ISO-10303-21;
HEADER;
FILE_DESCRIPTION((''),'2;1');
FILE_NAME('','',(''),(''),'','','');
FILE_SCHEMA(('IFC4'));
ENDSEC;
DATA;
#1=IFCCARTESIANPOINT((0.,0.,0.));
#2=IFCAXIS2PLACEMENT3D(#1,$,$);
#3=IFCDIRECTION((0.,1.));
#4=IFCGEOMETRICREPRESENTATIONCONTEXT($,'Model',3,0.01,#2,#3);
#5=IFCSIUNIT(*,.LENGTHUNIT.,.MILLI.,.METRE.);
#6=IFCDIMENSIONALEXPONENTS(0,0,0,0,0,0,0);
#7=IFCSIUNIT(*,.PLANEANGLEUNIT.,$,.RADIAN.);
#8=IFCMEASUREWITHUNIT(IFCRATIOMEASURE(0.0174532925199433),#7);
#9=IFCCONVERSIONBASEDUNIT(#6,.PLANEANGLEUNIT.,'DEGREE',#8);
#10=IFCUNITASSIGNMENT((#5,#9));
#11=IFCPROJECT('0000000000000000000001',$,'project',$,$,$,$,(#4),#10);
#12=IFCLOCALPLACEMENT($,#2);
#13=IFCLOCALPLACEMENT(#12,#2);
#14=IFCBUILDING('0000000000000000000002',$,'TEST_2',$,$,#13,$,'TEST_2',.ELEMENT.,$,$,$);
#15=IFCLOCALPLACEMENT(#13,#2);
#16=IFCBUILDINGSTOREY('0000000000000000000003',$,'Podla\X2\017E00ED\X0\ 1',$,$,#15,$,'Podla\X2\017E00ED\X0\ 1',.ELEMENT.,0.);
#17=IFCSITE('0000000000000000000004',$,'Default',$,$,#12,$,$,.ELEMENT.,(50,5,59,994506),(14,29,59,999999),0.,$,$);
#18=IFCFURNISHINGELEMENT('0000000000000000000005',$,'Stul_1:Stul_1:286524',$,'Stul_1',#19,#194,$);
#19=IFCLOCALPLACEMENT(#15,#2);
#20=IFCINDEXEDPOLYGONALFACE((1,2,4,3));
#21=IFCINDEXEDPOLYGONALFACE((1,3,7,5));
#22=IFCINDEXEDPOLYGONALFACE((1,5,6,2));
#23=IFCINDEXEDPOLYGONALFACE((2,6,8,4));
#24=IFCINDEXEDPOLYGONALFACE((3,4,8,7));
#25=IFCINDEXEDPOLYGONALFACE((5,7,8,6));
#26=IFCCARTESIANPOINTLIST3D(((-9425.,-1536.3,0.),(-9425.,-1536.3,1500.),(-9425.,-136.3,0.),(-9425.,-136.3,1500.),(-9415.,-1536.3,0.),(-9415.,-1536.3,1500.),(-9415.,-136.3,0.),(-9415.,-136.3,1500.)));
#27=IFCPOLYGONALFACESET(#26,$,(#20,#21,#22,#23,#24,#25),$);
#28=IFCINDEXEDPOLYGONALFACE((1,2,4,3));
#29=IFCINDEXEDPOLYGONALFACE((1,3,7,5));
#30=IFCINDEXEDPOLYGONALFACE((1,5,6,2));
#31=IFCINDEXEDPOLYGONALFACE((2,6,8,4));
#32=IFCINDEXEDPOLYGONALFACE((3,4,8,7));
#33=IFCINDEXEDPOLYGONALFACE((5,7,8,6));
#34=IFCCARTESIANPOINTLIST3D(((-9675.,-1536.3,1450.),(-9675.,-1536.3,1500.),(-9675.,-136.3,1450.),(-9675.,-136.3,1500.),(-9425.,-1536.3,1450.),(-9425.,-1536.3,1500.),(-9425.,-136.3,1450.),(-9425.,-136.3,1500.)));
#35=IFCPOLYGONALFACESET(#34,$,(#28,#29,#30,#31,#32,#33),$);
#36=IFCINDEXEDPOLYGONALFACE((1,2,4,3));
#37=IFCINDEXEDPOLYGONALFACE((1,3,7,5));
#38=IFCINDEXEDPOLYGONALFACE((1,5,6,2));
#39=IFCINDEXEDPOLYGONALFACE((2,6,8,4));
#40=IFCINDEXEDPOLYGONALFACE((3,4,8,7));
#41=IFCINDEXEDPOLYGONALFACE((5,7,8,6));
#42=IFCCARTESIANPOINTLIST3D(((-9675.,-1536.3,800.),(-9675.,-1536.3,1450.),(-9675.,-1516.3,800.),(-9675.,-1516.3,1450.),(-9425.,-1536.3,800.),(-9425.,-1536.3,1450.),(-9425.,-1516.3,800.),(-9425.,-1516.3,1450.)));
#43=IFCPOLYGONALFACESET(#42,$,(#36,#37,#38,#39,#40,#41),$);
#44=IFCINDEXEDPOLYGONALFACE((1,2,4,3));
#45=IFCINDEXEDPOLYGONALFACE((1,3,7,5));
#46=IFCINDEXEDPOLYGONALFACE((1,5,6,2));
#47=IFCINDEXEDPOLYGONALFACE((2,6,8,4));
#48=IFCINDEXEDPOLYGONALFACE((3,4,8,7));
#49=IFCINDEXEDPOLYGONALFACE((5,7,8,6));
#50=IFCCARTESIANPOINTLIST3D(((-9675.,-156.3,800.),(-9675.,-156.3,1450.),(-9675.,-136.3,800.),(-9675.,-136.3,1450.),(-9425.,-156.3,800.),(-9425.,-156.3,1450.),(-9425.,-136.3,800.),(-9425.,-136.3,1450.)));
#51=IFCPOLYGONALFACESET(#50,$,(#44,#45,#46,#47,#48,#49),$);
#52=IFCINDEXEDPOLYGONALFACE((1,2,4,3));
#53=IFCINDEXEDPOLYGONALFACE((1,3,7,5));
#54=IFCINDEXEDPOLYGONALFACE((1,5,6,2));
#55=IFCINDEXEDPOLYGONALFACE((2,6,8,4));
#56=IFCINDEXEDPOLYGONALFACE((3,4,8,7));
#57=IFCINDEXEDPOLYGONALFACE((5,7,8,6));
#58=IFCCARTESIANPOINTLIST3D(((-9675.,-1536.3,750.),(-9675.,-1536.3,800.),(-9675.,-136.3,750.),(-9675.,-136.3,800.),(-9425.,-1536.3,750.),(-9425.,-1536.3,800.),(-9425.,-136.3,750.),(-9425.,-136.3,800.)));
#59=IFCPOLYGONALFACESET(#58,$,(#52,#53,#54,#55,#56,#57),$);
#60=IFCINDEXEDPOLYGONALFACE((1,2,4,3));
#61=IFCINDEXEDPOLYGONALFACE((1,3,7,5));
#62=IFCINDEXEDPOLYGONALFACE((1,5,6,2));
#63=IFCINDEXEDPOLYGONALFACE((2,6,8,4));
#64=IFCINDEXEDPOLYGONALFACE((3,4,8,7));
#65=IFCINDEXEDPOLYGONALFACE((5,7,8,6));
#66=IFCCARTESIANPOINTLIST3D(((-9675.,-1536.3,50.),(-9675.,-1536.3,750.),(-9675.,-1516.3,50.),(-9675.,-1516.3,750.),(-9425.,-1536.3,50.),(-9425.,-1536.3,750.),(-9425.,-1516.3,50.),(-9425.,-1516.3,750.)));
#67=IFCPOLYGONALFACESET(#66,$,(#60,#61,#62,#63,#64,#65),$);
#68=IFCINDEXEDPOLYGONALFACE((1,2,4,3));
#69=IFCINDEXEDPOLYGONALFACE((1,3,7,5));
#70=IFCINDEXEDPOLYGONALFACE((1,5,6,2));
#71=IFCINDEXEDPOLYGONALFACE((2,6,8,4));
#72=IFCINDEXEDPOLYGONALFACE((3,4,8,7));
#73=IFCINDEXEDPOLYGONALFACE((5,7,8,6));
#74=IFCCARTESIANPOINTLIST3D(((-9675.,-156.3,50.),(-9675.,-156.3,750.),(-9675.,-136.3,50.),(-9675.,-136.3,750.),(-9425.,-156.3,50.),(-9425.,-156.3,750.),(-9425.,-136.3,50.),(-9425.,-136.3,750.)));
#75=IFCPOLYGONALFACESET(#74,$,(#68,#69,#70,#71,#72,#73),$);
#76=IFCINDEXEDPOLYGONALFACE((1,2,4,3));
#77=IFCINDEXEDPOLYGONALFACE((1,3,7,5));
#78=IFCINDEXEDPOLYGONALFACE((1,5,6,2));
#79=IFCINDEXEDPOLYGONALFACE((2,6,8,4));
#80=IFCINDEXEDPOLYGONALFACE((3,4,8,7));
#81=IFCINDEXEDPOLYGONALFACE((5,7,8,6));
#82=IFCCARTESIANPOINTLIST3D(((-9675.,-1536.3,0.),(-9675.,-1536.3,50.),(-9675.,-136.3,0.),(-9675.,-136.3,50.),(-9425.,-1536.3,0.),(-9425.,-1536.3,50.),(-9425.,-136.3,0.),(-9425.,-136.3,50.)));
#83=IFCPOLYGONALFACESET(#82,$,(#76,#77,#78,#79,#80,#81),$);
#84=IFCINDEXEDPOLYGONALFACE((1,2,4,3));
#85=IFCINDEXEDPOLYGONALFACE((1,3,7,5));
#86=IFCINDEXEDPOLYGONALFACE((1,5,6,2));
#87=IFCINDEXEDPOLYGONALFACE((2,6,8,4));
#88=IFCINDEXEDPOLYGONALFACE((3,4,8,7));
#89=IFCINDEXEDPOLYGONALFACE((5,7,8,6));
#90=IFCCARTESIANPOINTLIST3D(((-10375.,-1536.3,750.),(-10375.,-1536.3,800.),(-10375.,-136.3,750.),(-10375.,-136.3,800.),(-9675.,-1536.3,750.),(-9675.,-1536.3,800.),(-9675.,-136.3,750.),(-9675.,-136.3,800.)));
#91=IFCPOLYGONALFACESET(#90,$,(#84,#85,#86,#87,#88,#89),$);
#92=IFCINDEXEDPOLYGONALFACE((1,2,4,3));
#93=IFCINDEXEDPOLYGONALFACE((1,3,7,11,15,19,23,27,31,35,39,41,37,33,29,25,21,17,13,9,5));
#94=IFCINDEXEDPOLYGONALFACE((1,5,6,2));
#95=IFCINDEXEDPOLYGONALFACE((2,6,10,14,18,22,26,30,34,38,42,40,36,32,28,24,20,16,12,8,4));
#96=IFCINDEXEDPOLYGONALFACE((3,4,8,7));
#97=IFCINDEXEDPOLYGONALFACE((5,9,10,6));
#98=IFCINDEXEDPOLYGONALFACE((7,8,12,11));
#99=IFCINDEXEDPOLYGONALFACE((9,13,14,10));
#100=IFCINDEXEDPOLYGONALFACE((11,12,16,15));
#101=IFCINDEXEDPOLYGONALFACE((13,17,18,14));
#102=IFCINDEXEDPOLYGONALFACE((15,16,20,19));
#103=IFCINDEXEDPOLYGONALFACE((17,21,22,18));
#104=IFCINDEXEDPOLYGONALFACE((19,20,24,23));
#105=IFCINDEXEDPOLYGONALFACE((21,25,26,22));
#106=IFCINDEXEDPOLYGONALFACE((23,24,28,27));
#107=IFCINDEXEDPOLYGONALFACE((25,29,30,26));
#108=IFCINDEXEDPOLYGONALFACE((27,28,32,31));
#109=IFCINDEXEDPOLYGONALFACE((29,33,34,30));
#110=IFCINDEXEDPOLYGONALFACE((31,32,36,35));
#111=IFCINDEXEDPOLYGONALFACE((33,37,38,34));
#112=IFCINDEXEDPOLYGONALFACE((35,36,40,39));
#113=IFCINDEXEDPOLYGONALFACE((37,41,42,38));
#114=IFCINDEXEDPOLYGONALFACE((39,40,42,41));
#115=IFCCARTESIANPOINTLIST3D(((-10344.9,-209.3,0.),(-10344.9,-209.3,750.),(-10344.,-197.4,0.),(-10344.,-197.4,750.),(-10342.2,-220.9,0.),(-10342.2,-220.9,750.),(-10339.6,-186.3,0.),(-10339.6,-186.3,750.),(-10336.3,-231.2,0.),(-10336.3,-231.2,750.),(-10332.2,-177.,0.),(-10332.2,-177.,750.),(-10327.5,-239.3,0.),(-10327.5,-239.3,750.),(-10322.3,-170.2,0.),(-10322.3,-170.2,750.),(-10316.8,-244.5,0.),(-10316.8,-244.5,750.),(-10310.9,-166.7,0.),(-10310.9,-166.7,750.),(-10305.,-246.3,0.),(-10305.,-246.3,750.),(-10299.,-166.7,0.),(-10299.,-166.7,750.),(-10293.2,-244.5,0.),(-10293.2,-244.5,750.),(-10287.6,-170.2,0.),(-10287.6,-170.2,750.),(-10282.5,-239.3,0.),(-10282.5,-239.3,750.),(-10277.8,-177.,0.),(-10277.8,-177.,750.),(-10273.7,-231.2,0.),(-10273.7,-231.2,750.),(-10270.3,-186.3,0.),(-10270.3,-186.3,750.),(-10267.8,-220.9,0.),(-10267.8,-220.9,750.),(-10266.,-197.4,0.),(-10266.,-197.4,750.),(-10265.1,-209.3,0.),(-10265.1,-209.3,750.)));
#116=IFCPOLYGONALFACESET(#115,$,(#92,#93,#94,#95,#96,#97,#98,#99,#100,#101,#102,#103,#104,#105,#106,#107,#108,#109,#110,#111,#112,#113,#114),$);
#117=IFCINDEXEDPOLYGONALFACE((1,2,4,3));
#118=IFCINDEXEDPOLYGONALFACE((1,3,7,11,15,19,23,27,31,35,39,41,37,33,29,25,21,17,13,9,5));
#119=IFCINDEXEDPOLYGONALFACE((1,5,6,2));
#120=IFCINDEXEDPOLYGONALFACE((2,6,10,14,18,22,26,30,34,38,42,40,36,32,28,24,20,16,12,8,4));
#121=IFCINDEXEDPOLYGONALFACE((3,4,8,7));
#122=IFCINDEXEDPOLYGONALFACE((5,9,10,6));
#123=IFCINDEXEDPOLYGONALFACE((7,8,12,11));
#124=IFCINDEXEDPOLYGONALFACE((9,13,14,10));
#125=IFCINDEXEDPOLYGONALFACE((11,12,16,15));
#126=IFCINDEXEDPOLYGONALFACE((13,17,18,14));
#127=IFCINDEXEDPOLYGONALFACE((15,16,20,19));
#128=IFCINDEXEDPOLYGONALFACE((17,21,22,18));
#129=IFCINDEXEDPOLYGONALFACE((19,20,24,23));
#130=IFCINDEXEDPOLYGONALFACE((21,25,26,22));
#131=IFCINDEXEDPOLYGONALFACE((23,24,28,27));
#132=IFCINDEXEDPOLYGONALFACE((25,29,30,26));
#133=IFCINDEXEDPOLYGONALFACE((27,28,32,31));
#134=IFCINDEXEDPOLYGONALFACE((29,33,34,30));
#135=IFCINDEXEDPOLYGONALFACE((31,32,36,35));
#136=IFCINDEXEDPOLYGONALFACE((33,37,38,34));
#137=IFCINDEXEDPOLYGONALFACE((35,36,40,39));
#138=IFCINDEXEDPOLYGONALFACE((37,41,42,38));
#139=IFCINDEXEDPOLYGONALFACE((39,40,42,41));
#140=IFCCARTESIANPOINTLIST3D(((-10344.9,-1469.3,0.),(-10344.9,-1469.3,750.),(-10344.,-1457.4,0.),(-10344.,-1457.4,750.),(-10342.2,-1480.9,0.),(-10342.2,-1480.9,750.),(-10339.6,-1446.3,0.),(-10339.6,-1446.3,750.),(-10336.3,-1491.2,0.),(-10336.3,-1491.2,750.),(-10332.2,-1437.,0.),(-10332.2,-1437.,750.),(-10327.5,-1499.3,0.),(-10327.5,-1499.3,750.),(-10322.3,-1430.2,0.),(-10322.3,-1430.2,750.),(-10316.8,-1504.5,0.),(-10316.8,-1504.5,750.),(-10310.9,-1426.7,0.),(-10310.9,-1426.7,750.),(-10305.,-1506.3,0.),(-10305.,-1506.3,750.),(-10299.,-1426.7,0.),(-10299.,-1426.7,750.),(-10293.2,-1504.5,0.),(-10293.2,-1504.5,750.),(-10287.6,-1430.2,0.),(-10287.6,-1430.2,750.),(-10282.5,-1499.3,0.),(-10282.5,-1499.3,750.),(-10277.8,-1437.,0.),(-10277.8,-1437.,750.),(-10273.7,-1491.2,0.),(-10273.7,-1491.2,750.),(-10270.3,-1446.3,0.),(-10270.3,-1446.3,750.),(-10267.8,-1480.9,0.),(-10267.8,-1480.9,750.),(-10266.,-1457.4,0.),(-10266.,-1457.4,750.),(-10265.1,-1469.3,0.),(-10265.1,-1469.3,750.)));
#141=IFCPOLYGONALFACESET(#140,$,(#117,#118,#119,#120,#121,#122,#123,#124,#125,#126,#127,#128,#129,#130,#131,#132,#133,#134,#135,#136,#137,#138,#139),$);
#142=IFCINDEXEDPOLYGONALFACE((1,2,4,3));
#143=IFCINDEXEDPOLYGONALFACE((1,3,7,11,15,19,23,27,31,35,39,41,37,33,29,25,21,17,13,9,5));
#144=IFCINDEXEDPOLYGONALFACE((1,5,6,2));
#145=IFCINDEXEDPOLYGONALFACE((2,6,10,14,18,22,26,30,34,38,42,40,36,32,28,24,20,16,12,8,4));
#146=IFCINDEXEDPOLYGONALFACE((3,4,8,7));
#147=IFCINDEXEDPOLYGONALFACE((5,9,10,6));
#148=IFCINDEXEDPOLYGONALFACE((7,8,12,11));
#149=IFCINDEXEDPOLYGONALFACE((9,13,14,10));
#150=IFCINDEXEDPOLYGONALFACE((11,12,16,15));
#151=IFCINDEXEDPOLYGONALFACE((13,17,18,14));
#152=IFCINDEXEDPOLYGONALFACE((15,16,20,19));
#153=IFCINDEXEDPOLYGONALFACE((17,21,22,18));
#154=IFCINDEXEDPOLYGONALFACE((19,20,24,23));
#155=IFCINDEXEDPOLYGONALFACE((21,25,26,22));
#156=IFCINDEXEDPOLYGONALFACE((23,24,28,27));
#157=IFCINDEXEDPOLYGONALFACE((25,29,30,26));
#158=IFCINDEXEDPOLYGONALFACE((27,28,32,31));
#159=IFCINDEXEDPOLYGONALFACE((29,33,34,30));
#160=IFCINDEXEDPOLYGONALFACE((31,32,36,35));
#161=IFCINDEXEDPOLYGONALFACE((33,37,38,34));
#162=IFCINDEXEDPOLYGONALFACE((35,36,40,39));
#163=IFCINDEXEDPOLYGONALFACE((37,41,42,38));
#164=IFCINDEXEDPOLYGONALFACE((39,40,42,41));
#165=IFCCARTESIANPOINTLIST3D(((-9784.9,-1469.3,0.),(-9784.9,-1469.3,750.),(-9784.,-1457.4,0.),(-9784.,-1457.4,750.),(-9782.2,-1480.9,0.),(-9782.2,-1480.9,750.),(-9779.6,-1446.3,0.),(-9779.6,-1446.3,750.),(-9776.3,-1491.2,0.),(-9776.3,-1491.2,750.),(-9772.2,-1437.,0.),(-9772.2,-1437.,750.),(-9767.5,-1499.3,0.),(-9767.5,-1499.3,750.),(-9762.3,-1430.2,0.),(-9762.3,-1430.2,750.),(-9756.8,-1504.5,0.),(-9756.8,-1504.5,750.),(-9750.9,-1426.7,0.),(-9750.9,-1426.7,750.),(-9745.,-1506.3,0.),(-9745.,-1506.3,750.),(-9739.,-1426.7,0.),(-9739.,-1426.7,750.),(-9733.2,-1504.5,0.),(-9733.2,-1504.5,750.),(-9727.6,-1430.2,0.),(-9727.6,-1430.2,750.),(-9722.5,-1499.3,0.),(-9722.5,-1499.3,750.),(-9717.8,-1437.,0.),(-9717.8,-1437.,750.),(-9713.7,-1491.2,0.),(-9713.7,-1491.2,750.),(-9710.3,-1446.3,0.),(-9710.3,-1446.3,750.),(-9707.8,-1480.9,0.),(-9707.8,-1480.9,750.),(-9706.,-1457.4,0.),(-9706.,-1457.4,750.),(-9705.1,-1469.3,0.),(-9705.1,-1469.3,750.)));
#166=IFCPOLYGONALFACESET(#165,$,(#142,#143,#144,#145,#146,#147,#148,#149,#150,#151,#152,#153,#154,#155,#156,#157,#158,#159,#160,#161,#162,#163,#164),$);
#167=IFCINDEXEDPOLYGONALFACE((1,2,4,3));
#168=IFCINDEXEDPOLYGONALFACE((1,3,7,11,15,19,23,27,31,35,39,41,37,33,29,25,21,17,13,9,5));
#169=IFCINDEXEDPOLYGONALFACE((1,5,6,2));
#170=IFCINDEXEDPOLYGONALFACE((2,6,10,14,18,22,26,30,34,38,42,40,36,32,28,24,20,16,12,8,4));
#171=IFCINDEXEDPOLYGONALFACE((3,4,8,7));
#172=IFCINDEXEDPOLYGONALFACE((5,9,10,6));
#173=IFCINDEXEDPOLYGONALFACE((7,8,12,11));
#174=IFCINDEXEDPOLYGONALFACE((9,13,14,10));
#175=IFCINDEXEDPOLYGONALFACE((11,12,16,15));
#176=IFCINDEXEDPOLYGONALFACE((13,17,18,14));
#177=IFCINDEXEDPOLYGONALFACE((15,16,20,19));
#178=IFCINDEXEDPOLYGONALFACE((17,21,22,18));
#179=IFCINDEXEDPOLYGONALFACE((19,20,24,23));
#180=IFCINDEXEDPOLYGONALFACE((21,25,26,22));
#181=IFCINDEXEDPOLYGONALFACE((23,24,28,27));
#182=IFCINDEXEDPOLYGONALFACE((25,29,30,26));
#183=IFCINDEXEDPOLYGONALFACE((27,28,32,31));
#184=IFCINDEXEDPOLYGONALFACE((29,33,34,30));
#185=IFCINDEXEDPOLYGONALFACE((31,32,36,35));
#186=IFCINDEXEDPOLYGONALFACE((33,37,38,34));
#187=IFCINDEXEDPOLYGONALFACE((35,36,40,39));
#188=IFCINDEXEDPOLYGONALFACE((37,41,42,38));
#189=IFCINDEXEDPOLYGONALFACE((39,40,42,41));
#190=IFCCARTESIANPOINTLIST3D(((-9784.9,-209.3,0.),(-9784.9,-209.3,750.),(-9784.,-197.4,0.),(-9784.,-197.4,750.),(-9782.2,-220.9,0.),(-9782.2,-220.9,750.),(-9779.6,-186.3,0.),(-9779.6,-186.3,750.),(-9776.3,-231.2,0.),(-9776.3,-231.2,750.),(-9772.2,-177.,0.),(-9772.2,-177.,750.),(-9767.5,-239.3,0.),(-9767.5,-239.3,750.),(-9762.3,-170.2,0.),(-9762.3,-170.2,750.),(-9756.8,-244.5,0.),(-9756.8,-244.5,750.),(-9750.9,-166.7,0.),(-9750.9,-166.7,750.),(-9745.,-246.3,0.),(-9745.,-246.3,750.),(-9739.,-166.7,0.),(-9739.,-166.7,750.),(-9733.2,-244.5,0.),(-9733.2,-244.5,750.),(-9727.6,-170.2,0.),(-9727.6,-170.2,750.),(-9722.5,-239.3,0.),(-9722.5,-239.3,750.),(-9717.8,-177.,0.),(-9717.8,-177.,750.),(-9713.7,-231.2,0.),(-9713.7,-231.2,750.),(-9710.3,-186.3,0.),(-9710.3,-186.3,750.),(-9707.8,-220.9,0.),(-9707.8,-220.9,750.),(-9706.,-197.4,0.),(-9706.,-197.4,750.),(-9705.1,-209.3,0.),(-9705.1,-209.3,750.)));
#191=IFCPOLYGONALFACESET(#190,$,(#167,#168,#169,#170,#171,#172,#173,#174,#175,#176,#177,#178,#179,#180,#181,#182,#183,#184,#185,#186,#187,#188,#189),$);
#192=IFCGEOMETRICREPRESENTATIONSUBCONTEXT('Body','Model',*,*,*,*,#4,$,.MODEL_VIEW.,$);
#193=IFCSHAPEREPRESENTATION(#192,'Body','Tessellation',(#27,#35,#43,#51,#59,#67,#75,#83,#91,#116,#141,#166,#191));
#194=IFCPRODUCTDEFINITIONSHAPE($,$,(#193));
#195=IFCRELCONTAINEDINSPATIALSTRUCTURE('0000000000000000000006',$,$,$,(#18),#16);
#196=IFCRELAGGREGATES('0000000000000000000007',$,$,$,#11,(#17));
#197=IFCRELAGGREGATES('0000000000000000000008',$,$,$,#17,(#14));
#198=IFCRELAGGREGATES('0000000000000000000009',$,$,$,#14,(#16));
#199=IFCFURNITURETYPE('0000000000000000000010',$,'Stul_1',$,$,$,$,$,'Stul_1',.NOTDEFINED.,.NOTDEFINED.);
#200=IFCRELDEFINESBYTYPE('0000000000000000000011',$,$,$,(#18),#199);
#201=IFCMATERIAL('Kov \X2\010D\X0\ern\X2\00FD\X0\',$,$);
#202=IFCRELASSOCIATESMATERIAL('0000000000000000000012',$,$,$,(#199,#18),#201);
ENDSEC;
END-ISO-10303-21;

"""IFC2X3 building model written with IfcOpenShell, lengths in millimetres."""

from ifc_helpers import new_model, entity, si_unit, converted_unit, direction, frame, frame_2d, origin, origin_2d_with_axis, place, context, subcontext, project, spatial, rectangle, circle, extrude, source, transform, mapped, material, type_object, type_shapes, element, save


model = new_model("IFC2X3")

# Units and contexts
model_context = context("Model", 3, precision=0.01, world=origin(), true_north=direction((0.0, 1.0)))
body_context = subcontext(model_context, "Body", "Model", "MODEL_VIEW")
ifc_project = project(units=[si_unit("LENGTHUNIT", "METRE", prefix="MILLI"), converted_unit("PLANEANGLEUNIT", "DEGREE", entity("IfcRatioMeasure", 0.0174532925199433), si_unit("PLANEANGLEUNIT", "RADIAN"), dimensions=[0, 0, 0, 0, 0, 0, 0])], contexts=[model_context])

# Site, building, storey
site_placement = place(None, origin())
site = spatial("IfcSite", under=ifc_project, at=site_placement, Name="Default", CompositionType="ELEMENT", RefLatitude=(50, 5, 59, 994506), RefLongitude=(14, 29, 59, 999999), RefElevation=0.0)
building_placement = place(site_placement, origin())
building = spatial("IfcBuilding", under=site, at=building_placement, Name="TEST_2", LongName="TEST_2", CompositionType="ELEMENT")
storey_placement = place(building_placement, origin())
storey = spatial("IfcBuildingStorey", under=building, at=storey_placement, Name="Podlaží 1", LongName="Podlaží 1", CompositionType="ELEMENT", Elevation=0.0)

# Furnishing element
ifc_material_1 = material(Name="Kov černý")
furniture_type = type_object("IfcFurnitureType", Name="Stul_1", ElementType="Stul_1", material=ifc_material_1)
shared_shape_1 = source(origin(), body_context, "Body", "SweptSolid", [
    extrude(rectangle(XDim=1400.0, YDim=10.0, at=origin_2d_with_axis()), frame((0.0, 605.0, 0.0), z_axis=(0.0, 0.0, 1.0), x_axis=(-1.0, 0.0, 0.0)), (0.0, 0.0, 1.0), 1500.0),
    extrude(rectangle(XDim=1400.0, YDim=250.0, at=frame_2d((0.0, 0.0), x_axis=(1.0, 0.0))), frame((0.0, 475.0, 1450.0), z_axis=(0.0, 0.0, 1.0), x_axis=(-1.0, 0.0, 0.0)), (0.0, 0.0, 1.0), 50.0),
    extrude(rectangle(XDim=20.0, YDim=250.0, at=origin_2d_with_axis()), frame((690.0, 475.0, 800.0), z_axis=(0.0, 0.0, 1.0), x_axis=(-1.0, 0.0, 0.0)), (0.0, 0.0, 1.0), 650.0),
    extrude(rectangle(XDim=20.0, YDim=250.0, at=frame_2d((0.0, 0.0), x_axis=(1.0, 0.0))), frame((-690.0, 475.0, 800.0), z_axis=(0.0, 0.0, 1.0), x_axis=(-1.0, 0.0, 0.0)), (0.0, 0.0, 1.0), 650.0),
    extrude(rectangle(XDim=1400.0, YDim=250.0, at=origin_2d_with_axis()), frame((0.0, 475.0, 750.0), z_axis=(0.0, 0.0, 1.0), x_axis=(-1.0, 0.0, 0.0)), (0.0, 0.0, 1.0), 50.0),
    extrude(rectangle(XDim=20.0, YDim=250.0, at=origin_2d_with_axis()), frame((690.0, 475.0, 50.0), z_axis=(0.0, 0.0, 1.0), x_axis=(-1.0, 0.0, 0.0)), (0.0, 0.0, 1.0), 700.0),
    extrude(rectangle(XDim=20.0, YDim=250.0, at=frame_2d((0.0, 0.0), x_axis=(1.0, 0.0))), frame((-690.0, 475.0, 50.0), z_axis=(0.0, 0.0, 1.0), x_axis=(-1.0, 0.0, 0.0)), (0.0, 0.0, 1.0), 700.0),
    extrude(rectangle(XDim=1400.0, YDim=250.0, at=origin_2d_with_axis()), frame((0.0, 475.0, 0.0), z_axis=(0.0, 0.0, 1.0), x_axis=(-1.0, 0.0, 0.0)), (0.0, 0.0, 1.0), 50.0),
    extrude(rectangle(XDim=1400.0, YDim=700.0, at=origin_2d_with_axis()), frame((0.0, 0.0, 750.0), z_axis=(0.0, 0.0, 1.0), x_axis=(-1.0, 0.0, 0.0)), (0.0, 0.0, 1.0), 50.0),
    extrude(circle(Radius=40.0, at=frame_2d((0.0, 0.0), x_axis=(1.0, 0.0))), frame((-630.0, -280.0, 0.0)), (0.0, 0.0, 1.0), 750.0),
    extrude(circle(Radius=40.0, at=frame_2d((0.0, 0.0), x_axis=(1.0, 0.0))), frame((630.0, -280.0, 0.0)), (0.0, 0.0, 1.0), 750.0),
    extrude(circle(Radius=40.0, at=frame_2d((0.0, 0.0), x_axis=(1.0, 0.0))), frame((630.0, 280.0, 0.0)), (0.0, 0.0, 1.0), 750.0),
    extrude(circle(Radius=40.0, at=frame_2d((0.0, 0.0), x_axis=(1.0, 0.0))), frame((-630.0, 280.0, 0.0)), (0.0, 0.0, 1.0), 750.0),
])
type_shapes(furniture_type, [shared_shape_1])
for number, where, z_axis, x_axis, name in (
    (1, (-10025.0, -836.3, 0.0), (0.0, 0.0, 1.0), (0.0, -1.0, 0.0), "Stul_1:Stul_1:286524"),
):
    element("IfcFurnishingElement", number, at=place(storey_placement, frame(where, z_axis=z_axis, x_axis=x_axis)), inside=storey, type_object=furniture_type, material=ifc_material_1, Name=name, ObjectType="Stul_1", context=body_context, shape_type="MappedRepresentation", body=[
        mapped(shared_shape_1, transform((0.0, 0.0, 0.0), scale=1.0)),
    ])

save(model, "model.ifc")
